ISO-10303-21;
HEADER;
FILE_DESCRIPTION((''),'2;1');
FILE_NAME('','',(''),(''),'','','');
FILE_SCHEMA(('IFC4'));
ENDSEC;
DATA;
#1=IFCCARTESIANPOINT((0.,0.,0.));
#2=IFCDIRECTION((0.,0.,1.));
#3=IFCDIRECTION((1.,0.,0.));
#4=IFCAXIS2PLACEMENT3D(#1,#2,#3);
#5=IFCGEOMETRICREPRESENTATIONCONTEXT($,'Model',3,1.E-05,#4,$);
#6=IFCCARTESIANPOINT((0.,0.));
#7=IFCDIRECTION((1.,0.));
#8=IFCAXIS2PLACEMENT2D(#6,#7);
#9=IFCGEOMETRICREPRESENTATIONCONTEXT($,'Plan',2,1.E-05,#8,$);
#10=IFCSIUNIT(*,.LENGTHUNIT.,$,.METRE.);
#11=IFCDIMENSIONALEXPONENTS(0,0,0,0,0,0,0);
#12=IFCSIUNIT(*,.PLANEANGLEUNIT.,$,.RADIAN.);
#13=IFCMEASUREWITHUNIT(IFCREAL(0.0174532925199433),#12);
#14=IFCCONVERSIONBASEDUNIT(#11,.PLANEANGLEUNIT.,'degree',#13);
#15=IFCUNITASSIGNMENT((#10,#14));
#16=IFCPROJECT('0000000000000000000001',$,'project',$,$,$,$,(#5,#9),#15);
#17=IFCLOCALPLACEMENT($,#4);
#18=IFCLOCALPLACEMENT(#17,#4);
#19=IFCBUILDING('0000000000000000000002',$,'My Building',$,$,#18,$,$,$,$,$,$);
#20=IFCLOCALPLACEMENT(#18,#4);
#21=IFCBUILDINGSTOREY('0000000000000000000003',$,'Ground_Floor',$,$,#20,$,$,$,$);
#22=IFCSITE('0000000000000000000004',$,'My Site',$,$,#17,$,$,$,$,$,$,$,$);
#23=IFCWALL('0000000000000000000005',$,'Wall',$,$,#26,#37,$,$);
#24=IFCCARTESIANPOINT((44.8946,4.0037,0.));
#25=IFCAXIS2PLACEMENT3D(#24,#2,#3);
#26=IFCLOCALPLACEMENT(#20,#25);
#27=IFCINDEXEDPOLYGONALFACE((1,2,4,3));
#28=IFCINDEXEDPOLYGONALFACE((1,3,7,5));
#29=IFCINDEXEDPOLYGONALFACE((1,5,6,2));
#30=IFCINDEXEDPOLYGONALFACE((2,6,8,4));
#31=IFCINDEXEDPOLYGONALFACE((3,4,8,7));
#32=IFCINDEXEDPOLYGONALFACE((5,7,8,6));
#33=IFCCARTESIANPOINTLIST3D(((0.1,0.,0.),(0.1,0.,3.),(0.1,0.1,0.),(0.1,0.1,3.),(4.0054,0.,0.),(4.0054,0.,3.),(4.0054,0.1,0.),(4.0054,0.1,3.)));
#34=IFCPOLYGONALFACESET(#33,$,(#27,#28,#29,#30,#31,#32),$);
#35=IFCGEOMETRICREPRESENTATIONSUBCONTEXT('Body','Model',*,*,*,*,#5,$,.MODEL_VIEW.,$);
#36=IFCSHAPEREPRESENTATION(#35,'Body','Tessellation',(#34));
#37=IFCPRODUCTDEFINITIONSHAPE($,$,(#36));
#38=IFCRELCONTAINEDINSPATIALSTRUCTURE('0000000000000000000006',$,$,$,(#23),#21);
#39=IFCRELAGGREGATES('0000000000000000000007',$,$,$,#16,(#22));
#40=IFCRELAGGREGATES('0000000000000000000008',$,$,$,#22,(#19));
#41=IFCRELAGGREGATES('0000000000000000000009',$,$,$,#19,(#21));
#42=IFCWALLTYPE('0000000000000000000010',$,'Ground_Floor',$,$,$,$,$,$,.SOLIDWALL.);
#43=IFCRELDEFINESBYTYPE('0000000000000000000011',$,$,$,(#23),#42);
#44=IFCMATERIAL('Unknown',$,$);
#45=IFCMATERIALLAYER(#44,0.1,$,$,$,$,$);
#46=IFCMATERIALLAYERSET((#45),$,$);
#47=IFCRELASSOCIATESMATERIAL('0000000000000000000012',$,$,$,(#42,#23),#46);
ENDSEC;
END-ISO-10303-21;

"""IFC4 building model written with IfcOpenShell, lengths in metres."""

from ifc_helpers import new_model, entity, si_unit, converted_unit, frame, origin_with_axes, origin_2d_with_axis, place, context, subcontext, project, spatial, line, indexed_curve, outline, extrude, material, layer, layer_set, layer_usage, type_object, element, save


model = new_model("IFC4")

# Units and contexts
model_context = context("Model", 3, precision=1e-05, world=origin_with_axes())
plan_context = context("Plan", 2, precision=1e-05, world=origin_2d_with_axis())
body_context_1 = subcontext(model_context, "Body", "Model", "MODEL_VIEW")
ifc_project = project(units=[si_unit("LENGTHUNIT", "METRE"), converted_unit("PLANEANGLEUNIT", "degree", entity("IfcReal", 0.0174532925199433), si_unit("PLANEANGLEUNIT", "RADIAN"), dimensions=[0, 0, 0, 0, 0, 0, 0])], contexts=[model_context, plan_context])

# Site, building, storey
site_placement = place(None, origin_with_axes())
site = spatial("IfcSite", under=ifc_project, at=site_placement, Name="My Site")
building_placement = place(site_placement, origin_with_axes())
building = spatial("IfcBuilding", under=site, at=building_placement, Name="My Building")
storey_placement = place(building_placement, origin_with_axes())
storey = spatial("IfcBuildingStorey", under=building, at=storey_placement, Name="Ground_Floor")

# Shared definitions
ifc_material = material(Name="Unknown")

# Shared definitions
ifc_layer = layer(ifc_material, 0.1)
ifc_layer_set = layer_set([ifc_layer])
wall_type = type_object("IfcWallType", Name="Ground_Floor", PredefinedType="SOLIDWALL", material=ifc_layer_set)

# Wall
ifc_layer_usage_1 = layer_usage(ifc_layer_set, "AXIS2", "POSITIVE", 0.0)
wall_1_placement = place(storey_placement, frame((44.8946, 4.0037, 0.0), z_axis=(0.0, 0.0, 1.0), x_axis=(1.0, 0.0, 0.0)))
element("IfcWall", 1, at=wall_1_placement, inside=storey, type_object=wall_type, material=ifc_layer_usage_1, Name="Wall", context=body_context_1, shape_type="SweptSolid", body=[
    extrude(outline(indexed_curve([(0.1, 0.0), (0.1, 0.1), (4.0054, 0.1), (4.0054, 0.0)], segments=[line(1, 2, 3, 4, 1)])), origin_with_axes(), (0.0, 0.0, 1.0), 3.0),
])

save(model, "model.ifc")
